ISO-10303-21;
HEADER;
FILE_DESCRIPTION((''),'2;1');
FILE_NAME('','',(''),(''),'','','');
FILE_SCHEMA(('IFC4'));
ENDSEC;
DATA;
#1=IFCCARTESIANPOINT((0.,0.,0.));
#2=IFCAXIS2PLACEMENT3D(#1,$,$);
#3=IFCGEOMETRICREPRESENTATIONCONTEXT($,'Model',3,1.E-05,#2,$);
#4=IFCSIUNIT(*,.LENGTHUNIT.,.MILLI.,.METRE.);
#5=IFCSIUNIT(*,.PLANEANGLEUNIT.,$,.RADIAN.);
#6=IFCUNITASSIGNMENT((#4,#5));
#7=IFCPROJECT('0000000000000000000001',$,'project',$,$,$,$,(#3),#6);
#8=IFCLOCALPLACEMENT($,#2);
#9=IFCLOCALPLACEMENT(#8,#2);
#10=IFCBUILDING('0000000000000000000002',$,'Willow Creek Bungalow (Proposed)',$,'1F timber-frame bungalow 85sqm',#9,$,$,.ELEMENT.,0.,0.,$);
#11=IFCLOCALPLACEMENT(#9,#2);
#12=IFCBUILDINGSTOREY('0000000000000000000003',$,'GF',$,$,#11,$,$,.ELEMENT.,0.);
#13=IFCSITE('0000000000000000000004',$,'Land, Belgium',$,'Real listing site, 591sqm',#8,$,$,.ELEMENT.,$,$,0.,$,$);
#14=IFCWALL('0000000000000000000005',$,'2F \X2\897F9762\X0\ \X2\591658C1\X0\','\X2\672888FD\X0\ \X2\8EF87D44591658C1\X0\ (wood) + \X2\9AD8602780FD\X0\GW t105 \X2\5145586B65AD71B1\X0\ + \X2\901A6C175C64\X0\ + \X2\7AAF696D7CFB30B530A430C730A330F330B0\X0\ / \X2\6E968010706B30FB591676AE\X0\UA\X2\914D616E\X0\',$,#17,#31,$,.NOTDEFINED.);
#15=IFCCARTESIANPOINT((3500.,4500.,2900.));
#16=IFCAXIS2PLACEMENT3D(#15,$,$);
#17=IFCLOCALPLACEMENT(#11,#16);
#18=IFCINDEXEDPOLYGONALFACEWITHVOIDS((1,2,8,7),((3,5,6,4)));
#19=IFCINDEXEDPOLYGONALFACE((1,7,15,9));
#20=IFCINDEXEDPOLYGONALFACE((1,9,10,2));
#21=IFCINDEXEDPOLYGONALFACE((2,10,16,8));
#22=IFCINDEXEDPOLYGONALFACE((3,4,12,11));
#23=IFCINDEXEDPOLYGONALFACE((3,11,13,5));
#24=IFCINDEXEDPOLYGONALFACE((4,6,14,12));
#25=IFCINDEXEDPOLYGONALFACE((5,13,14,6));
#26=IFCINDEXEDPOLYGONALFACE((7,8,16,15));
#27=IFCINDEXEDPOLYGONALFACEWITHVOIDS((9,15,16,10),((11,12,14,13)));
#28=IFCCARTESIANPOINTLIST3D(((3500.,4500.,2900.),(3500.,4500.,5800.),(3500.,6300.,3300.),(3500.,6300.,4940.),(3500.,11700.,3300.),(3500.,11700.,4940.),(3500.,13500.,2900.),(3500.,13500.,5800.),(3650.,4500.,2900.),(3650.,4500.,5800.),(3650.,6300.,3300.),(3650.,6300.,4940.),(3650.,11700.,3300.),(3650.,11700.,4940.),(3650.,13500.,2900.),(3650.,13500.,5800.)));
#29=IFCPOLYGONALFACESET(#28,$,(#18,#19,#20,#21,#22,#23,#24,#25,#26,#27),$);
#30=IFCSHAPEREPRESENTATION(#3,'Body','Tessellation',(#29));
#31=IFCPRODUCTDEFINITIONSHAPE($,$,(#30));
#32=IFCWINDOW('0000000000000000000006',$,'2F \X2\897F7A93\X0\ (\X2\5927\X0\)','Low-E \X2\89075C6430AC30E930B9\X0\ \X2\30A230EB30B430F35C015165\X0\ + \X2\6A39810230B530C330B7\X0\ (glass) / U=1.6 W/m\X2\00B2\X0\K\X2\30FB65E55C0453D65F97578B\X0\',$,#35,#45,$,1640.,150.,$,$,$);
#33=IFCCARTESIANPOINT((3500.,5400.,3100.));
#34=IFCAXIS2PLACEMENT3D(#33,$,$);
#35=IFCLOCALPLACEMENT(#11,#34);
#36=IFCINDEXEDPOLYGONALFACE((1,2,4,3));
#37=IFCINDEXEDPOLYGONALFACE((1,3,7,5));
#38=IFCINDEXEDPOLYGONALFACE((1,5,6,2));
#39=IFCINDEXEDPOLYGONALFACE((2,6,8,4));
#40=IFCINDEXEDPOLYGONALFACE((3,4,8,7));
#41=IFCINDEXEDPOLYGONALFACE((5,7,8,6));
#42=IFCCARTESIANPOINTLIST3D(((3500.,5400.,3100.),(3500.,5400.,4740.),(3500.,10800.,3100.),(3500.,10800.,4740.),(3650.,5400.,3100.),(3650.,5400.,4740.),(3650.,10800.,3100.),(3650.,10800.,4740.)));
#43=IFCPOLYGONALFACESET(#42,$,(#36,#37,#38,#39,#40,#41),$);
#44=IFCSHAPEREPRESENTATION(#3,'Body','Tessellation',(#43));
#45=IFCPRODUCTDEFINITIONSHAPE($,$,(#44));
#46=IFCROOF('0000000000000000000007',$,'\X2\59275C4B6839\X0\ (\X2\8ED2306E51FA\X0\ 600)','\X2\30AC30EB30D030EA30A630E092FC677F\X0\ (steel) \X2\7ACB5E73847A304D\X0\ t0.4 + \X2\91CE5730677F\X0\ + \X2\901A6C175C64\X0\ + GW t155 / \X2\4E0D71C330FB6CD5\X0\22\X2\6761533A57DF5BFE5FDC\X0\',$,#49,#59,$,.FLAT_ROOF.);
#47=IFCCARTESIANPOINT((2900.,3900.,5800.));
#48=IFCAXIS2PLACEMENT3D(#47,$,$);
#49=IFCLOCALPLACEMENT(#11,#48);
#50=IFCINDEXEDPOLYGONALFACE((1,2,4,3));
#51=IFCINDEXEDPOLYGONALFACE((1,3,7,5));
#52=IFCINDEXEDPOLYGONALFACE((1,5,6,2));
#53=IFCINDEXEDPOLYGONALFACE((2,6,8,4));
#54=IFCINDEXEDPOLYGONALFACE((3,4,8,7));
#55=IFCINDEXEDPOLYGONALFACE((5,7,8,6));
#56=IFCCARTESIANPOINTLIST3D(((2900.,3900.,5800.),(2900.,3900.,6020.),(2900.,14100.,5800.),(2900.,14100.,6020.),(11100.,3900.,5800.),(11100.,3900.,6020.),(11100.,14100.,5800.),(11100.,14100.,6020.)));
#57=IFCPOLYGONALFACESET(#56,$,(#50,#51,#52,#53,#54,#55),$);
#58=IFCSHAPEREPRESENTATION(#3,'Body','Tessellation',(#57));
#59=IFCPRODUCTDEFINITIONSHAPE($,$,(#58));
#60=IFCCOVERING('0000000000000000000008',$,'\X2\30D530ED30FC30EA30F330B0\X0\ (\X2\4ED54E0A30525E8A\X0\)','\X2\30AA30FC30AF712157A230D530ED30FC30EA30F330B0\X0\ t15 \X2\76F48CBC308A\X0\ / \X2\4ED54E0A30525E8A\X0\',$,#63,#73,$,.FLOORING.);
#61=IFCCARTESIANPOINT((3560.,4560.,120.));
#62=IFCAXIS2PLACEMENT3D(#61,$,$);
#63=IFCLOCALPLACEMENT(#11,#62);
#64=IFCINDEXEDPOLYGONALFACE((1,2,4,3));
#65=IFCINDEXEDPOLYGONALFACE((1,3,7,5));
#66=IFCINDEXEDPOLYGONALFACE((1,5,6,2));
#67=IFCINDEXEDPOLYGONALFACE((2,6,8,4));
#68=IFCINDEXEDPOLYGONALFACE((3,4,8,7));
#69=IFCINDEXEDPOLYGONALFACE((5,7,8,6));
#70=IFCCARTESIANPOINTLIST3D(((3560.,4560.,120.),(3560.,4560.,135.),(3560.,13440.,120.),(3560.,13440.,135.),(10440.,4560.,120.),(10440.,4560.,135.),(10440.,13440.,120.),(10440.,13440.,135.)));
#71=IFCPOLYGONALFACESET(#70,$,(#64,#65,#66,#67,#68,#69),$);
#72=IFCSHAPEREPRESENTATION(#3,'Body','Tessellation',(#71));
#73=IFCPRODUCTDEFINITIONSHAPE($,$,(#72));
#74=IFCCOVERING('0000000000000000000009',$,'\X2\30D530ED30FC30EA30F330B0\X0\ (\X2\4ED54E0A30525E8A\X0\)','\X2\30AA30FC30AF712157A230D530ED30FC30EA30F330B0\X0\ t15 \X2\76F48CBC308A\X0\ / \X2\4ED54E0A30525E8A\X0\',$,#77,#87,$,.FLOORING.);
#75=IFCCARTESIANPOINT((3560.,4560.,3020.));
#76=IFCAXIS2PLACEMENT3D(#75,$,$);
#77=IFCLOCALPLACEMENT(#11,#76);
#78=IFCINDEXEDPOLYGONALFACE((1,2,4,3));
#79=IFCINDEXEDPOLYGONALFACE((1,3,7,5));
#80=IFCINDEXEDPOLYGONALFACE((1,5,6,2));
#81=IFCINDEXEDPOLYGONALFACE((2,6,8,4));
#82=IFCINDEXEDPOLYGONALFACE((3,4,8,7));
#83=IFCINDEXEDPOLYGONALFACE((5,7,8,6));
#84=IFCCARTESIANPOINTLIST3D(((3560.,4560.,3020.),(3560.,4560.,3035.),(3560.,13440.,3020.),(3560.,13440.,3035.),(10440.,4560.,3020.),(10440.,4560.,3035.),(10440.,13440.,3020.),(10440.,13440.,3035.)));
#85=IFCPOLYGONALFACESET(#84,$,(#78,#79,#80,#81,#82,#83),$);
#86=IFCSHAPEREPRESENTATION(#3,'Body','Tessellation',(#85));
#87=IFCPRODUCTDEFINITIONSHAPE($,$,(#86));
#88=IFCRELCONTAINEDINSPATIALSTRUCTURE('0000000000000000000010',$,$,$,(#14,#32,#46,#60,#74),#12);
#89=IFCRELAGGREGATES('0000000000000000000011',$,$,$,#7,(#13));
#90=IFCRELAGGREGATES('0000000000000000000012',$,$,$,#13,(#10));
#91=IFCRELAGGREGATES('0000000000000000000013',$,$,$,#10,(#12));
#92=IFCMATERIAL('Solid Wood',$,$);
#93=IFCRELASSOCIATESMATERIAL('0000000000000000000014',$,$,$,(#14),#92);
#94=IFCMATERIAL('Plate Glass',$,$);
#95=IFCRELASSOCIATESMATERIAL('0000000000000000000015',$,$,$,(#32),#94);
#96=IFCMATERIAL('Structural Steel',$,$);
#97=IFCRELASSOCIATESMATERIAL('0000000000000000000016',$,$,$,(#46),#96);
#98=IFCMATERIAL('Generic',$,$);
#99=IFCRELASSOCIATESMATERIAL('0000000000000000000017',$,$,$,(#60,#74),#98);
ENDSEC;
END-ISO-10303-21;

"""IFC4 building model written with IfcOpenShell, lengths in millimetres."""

from ifc_helpers import new_model, si_unit, frame, frame_2d, origin, place, context, project, spatial, rectangle, extrude, material, element, fill, save


model = new_model("IFC4")

# Units and contexts
model_context = context("Model", 3, precision=1e-05, world=origin())
ifc_project = project(units=[si_unit("LENGTHUNIT", "METRE", prefix="MILLI"), si_unit("PLANEANGLEUNIT", "RADIAN")], contexts=[model_context])

# Site, building, storey
site_placement = place(None, origin())
site = spatial("IfcSite", under=ifc_project, at=site_placement, Name="Land, Belgium", ObjectType="Real listing site, 591sqm", CompositionType="ELEMENT", RefElevation=0.0)
building_placement = place(site_placement, origin())
building = spatial("IfcBuilding", under=site, at=building_placement, Name="Willow Creek Bungalow (Proposed)", ObjectType="1F timber-frame bungalow 85sqm", CompositionType="ELEMENT", ElevationOfRefHeight=0.0, ElevationOfTerrain=0.0)
storey_placement = place(building_placement, origin())
storey = spatial("IfcBuildingStorey", under=building, at=storey_placement, Name="GF", CompositionType="ELEMENT", Elevation=0.0)

# Shared definitions
ifc_material_1 = material(Name="Solid Wood")
ifc_material_2 = material(Name="Generic")

# Shared definitions
ifc_material_3 = material(Name="Plate Glass")

# Wall, opening, window
wall_1_placement = place(storey_placement, frame((3500.0, 4500.0, 2900.0)))
wall_1 = element("IfcWall", 1, at=wall_1_placement, inside=storey, material=ifc_material_1, Name="2F 西面 外壁", Description="木製 軸組外壁 (wood) + 高性能GW t105 充填断熱 + 通気層 + 窯業系サイディング / 準耐火・外皮UA配慮", PredefinedType="NOTDEFINED", context=model_context, shape_type="SweptSolid", body=[
    extrude(rectangle(XDim=150.0, YDim=9000.0, at=frame_2d((75.0, 4500.0))), frame((3500.0, 4500.0, 2900.0)), (0.0, 0.0, 1.0), 2900.0),
])
opening_1_placement = place(storey_placement, frame((3500.0, 5400.0, 3100.0)))
opening_1 = element("IfcOpeningElement", 2, at=opening_1_placement, cuts=wall_1, PredefinedType="NOTDEFINED", context=model_context, shape_type="SweptSolid", body=[
    extrude(rectangle(XDim=150.0, YDim=5400.0, at=frame_2d((75.0, 2700.0))), frame((3500.0, 5400.0, 3100.0)), (0.0, 0.0, 1.0), 1640.0),
])
window_1_placement = place(storey_placement, frame((3500.0, 5400.0, 3100.0)))
window_1 = element("IfcWindow", 3, at=window_1_placement, inside=storey, material=ifc_material_3, Name="2F 西窓 (大)", Description="Low-E 複層ガラス アルゴン封入 + 樹脂サッシ (glass) / U=1.6 W/m²K・日射取得型", OverallHeight=1640.0, OverallWidth=150.0, context=model_context, shape_type="SweptSolid", body=[
    extrude(rectangle(XDim=150.0, YDim=5400.0, at=frame_2d((75.0, 2700.0))), frame((3500.0, 5400.0, 3100.0)), (0.0, 0.0, 1.0), 1640.0),
])
fill(opening_1, window_1)

# Roof
ifc_material_4 = material(Name="Structural Steel")
roof_placement = place(storey_placement, frame((2900.0, 3900.0, 5800.0)))
element("IfcRoof", 4, at=roof_placement, inside=storey, material=ifc_material_4, Name="大屋根 (軒の出 600)", Description="ガルバリウム鋼板 (steel) 立平葺き t0.4 + 野地板 + 通気層 + GW t155 / 不燃・法22条区域対応", PredefinedType="FLAT_ROOF", context=model_context, shape_type="SweptSolid", body=[
    extrude(rectangle(XDim=8200.0, YDim=10200.0, at=frame_2d((4100.0, 5100.0))), frame((2900.0, 3900.0, 5800.0)), (0.0, 0.0, 1.0), 220.0),
])

# Coverings
covering_1_placement = place(storey_placement, frame((3560.0, 4560.0, 120.0)))
element("IfcCovering", 5, at=covering_1_placement, inside=storey, material=ifc_material_2, Name="フローリング (仕上げ床)", Description="オーク無垢フローリング t15 直貼り / 仕上げ床", PredefinedType="FLOORING", context=model_context, shape_type="SweptSolid", body=[
    extrude(rectangle(XDim=6880.0, YDim=8880.0, at=frame_2d((3440.0, 4440.0))), frame((3560.0, 4560.0, 120.0)), (0.0, 0.0, 1.0), 15.0),
])
covering_2_placement = place(storey_placement, frame((3560.0, 4560.0, 3020.0)))
element("IfcCovering", 6, at=covering_2_placement, inside=storey, material=ifc_material_2, Name="フローリング (仕上げ床)", Description="オーク無垢フローリング t15 直貼り / 仕上げ床", PredefinedType="FLOORING", context=model_context, shape_type="SweptSolid", body=[
    extrude(rectangle(XDim=6880.0, YDim=8880.0, at=frame_2d((3440.0, 4440.0))), frame((3560.0, 4560.0, 3020.0)), (0.0, 0.0, 1.0), 15.0),
])

save(model, "model.ifc")
